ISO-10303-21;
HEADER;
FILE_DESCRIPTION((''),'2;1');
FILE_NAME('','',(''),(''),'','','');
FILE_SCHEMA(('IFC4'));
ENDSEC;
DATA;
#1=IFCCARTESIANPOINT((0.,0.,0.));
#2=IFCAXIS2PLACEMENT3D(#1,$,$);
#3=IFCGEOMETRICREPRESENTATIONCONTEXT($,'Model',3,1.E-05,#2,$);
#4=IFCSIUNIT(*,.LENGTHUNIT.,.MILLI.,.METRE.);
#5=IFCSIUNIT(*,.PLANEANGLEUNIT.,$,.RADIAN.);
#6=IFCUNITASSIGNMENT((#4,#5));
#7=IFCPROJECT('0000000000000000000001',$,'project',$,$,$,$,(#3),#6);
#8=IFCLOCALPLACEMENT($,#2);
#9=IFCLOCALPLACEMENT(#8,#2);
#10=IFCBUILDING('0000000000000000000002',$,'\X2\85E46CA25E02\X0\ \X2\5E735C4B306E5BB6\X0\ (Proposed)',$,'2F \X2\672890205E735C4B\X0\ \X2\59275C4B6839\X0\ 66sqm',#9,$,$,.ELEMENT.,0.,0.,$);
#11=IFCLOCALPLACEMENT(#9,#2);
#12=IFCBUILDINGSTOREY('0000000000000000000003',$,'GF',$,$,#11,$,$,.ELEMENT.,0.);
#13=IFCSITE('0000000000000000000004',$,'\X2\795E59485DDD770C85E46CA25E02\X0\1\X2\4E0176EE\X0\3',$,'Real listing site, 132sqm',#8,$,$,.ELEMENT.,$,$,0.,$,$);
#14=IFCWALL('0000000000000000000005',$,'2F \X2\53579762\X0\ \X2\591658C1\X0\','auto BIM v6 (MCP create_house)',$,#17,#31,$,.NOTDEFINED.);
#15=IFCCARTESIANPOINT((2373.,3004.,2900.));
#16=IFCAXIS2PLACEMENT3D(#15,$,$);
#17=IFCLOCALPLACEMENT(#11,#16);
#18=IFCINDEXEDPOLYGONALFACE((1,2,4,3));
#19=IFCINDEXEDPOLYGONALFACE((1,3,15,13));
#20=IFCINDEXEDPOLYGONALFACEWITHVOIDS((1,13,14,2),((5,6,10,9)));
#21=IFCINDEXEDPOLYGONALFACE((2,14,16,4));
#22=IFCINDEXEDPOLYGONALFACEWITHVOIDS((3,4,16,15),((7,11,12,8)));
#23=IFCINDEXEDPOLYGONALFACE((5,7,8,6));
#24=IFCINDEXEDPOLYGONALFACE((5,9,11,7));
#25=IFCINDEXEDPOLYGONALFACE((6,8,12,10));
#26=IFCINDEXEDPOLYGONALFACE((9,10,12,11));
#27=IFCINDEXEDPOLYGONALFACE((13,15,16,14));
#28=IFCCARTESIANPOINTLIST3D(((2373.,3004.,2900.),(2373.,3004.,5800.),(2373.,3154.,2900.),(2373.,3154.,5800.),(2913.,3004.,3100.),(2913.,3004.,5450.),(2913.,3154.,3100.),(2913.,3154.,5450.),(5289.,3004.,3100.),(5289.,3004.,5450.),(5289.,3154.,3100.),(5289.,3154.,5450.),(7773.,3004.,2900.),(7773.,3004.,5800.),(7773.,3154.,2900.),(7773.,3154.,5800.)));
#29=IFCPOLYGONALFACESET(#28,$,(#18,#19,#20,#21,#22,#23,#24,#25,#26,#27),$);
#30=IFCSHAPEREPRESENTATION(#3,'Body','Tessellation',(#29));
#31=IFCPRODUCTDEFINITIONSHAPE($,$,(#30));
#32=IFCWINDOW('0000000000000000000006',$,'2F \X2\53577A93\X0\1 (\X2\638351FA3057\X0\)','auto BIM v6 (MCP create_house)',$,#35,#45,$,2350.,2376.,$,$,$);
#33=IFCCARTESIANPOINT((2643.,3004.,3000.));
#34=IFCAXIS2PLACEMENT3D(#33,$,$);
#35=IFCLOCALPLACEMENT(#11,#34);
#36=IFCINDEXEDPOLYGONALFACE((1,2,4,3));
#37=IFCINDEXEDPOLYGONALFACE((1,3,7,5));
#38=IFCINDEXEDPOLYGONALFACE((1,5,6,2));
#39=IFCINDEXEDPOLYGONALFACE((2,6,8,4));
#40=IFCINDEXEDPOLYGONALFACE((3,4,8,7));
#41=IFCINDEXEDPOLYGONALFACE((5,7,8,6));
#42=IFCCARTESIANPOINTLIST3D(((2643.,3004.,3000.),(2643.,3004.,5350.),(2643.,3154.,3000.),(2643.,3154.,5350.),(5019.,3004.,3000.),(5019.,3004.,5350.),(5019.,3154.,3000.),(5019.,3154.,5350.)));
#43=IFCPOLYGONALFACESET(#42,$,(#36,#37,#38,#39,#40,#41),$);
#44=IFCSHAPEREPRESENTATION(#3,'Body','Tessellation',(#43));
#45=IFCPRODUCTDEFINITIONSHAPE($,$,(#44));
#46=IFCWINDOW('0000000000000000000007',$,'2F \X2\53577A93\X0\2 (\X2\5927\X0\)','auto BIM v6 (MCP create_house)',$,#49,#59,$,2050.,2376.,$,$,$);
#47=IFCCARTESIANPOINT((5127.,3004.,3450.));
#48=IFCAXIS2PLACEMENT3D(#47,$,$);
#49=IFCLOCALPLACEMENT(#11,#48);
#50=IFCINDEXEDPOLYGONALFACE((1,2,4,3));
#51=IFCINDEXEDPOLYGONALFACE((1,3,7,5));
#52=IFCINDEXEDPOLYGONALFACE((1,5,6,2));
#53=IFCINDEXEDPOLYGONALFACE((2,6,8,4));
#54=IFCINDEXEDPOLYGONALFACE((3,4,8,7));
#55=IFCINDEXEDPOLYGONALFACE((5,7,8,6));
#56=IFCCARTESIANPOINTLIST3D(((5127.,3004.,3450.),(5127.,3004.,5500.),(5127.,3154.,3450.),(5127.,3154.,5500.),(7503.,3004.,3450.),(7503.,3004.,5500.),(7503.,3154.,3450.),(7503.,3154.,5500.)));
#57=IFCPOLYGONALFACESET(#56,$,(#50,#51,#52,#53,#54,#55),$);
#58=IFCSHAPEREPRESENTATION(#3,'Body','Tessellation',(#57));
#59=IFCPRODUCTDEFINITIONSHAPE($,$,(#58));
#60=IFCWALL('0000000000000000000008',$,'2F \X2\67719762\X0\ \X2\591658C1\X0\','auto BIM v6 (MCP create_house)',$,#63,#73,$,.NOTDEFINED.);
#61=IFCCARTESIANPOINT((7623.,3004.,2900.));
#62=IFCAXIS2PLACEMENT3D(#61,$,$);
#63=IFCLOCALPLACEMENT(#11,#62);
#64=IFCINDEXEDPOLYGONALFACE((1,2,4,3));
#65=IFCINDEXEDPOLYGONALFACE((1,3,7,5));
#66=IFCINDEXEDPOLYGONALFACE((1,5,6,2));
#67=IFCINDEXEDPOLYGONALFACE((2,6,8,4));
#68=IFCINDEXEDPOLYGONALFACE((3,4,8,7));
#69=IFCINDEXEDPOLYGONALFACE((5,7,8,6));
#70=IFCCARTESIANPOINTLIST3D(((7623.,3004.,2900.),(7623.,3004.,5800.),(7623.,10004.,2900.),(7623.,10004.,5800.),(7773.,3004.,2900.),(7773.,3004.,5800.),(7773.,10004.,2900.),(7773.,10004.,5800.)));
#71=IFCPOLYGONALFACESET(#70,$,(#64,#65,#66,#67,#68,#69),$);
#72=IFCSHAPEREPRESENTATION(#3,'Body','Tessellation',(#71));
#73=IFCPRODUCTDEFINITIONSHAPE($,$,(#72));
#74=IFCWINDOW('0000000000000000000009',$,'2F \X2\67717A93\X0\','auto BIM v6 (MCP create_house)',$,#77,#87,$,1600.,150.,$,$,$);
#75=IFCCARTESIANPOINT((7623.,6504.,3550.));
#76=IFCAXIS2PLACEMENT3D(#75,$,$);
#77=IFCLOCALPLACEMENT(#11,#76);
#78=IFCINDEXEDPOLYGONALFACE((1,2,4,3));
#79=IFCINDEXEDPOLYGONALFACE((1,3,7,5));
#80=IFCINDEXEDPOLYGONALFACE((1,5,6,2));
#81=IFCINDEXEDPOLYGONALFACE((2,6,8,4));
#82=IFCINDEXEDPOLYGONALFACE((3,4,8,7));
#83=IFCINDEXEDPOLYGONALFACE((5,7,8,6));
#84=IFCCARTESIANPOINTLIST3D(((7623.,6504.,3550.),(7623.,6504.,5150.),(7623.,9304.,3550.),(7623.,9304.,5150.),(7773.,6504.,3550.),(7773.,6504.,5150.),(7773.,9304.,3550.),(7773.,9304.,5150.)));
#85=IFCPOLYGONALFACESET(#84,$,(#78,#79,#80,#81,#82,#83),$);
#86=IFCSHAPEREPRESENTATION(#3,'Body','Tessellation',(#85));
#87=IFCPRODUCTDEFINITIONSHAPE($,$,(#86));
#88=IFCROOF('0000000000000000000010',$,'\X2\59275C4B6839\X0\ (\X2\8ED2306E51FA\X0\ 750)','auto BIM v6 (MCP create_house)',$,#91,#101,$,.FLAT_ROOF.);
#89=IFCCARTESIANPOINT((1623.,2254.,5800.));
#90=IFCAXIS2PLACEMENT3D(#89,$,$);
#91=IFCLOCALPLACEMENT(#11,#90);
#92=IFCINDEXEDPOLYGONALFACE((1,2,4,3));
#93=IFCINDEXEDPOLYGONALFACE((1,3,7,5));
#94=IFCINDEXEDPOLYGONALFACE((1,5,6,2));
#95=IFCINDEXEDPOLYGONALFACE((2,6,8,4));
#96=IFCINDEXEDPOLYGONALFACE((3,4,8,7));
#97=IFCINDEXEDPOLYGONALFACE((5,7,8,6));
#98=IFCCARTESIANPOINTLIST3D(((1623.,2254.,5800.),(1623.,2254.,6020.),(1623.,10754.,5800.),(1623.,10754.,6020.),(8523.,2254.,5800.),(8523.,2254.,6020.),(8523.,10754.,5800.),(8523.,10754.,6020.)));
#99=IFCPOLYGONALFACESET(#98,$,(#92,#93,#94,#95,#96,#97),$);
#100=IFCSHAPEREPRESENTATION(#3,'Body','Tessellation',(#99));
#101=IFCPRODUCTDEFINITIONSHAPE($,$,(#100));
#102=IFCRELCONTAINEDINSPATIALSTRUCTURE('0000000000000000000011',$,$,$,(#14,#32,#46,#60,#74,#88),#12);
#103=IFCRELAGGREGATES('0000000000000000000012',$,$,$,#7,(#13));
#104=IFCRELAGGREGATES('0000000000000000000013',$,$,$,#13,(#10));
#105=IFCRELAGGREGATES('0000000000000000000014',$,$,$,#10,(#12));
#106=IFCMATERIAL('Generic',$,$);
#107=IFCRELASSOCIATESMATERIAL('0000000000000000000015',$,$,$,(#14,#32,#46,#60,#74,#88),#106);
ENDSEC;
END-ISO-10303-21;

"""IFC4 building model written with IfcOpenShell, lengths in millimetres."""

from ifc_helpers import new_model, si_unit, frame, frame_2d, origin, place, context, project, spatial, rectangle, extrude, material, element, fill, save


model = new_model("IFC4")

# Units and contexts
model_context = context("Model", 3, precision=1e-05, world=origin())
ifc_project = project(units=[si_unit("LENGTHUNIT", "METRE", prefix="MILLI"), si_unit("PLANEANGLEUNIT", "RADIAN")], contexts=[model_context])

# Site, building, storey
site_placement = place(None, origin())
site = spatial("IfcSite", under=ifc_project, at=site_placement, Name="神奈川県藤沢市1丁目3", ObjectType="Real listing site, 132sqm", CompositionType="ELEMENT", RefElevation=0.0)
building_placement = place(site_placement, origin())
building = spatial("IfcBuilding", under=site, at=building_placement, Name="藤沢市 平屋の家 (Proposed)", ObjectType="2F 木造平屋 大屋根 66sqm", CompositionType="ELEMENT", ElevationOfRefHeight=0.0, ElevationOfTerrain=0.0)
storey_placement = place(building_placement, origin())
storey = spatial("IfcBuildingStorey", under=building, at=storey_placement, Name="GF", CompositionType="ELEMENT", Elevation=0.0)

# Shared definitions
ifc_material = material(Name="Generic")

# Wall, openings, windows
wall_1_placement = place(storey_placement, frame((2373.0, 3004.0, 2900.0)))
wall_1 = element("IfcWall", 1, at=wall_1_placement, inside=storey, material=ifc_material, Name="2F 南面 外壁", Description="auto BIM v6 (MCP create_house)", PredefinedType="NOTDEFINED", context=model_context, shape_type="SweptSolid", body=[
    extrude(rectangle(XDim=5400.0, YDim=150.0, at=frame_2d((2700.0, 75.0))), frame((2373.0, 3004.0, 2900.0)), (0.0, 0.0, 1.0), 2900.0),
])
opening_1_placement = place(storey_placement, frame((2643.0, 3004.0, 3000.0)))
opening_1 = element("IfcOpeningElement", 2, at=opening_1_placement, cuts=wall_1, PredefinedType="NOTDEFINED", context=model_context, shape_type="SweptSolid", body=[
    extrude(rectangle(XDim=2376.0, YDim=150.0, at=frame_2d((1188.0, 75.0))), frame((2643.0, 3004.0, 3000.0)), (0.0, 0.0, 1.0), 2350.0),
])
opening_2_placement = place(storey_placement, frame((5127.0, 3004.0, 3450.0)))
opening_2 = element("IfcOpeningElement", 3, at=opening_2_placement, cuts=wall_1, PredefinedType="NOTDEFINED", context=model_context, shape_type="SweptSolid", body=[
    extrude(rectangle(XDim=2376.0, YDim=150.0, at=frame_2d((1188.0, 75.0))), frame((5127.0, 3004.0, 3450.0)), (0.0, 0.0, 1.0), 2050.0),
])
window_1_placement = place(storey_placement, frame((2643.0, 3004.0, 3000.0)))
window_1 = element("IfcWindow", 4, at=window_1_placement, inside=storey, material=ifc_material, Name="2F 南窓1 (掃出し)", Description="auto BIM v6 (MCP create_house)", OverallHeight=2350.0, OverallWidth=2376.0, context=model_context, shape_type="SweptSolid", body=[
    extrude(rectangle(XDim=2376.0, YDim=150.0, at=frame_2d((1188.0, 75.0))), frame((2643.0, 3004.0, 3000.0)), (0.0, 0.0, 1.0), 2350.0),
])
fill(opening_1, window_1)
window_2_placement = place(storey_placement, frame((5127.0, 3004.0, 3450.0)))
window_2 = element("IfcWindow", 5, at=window_2_placement, inside=storey, material=ifc_material, Name="2F 南窓2 (大)", Description="auto BIM v6 (MCP create_house)", OverallHeight=2050.0, OverallWidth=2376.0, context=model_context, shape_type="SweptSolid", body=[
    extrude(rectangle(XDim=2376.0, YDim=150.0, at=frame_2d((1188.0, 75.0))), frame((5127.0, 3004.0, 3450.0)), (0.0, 0.0, 1.0), 2050.0),
])
fill(opening_2, window_2)

# Wall, opening, window
wall_2_placement = place(storey_placement, frame((7623.0, 3004.0, 2900.0)))
wall_2 = element("IfcWall", 6, at=wall_2_placement, inside=storey, material=ifc_material, Name="2F 東面 外壁", Description="auto BIM v6 (MCP create_house)", PredefinedType="NOTDEFINED", context=model_context, shape_type="SweptSolid", body=[
    extrude(rectangle(XDim=150.0, YDim=7000.0, at=frame_2d((75.0, 3500.0))), frame((7623.0, 3004.0, 2900.0)), (0.0, 0.0, 1.0), 2900.0),
])
opening_3_placement = place(storey_placement, frame((7623.0, 6504.0, 3550.0)))
opening_3 = element("IfcOpeningElement", 7, at=opening_3_placement, cuts=wall_2, PredefinedType="NOTDEFINED", context=model_context, shape_type="SweptSolid", body=[
    extrude(rectangle(XDim=150.0, YDim=2800.0, at=frame_2d((75.0, 1400.0))), frame((7623.0, 6504.0, 3550.0)), (0.0, 0.0, 1.0), 1600.0),
])
window_3_placement = place(storey_placement, frame((7623.0, 6504.0, 3550.0)))
window_3 = element("IfcWindow", 8, at=window_3_placement, inside=storey, material=ifc_material, Name="2F 東窓", Description="auto BIM v6 (MCP create_house)", OverallHeight=1600.0, OverallWidth=150.0, context=model_context, shape_type="SweptSolid", body=[
    extrude(rectangle(XDim=150.0, YDim=2800.0, at=frame_2d((75.0, 1400.0))), frame((7623.0, 6504.0, 3550.0)), (0.0, 0.0, 1.0), 1600.0),
])
fill(opening_3, window_3)

# Roof
roof_placement = place(storey_placement, frame((1623.0, 2254.0, 5800.0)))
element("IfcRoof", 9, at=roof_placement, inside=storey, material=ifc_material, Name="大屋根 (軒の出 750)", Description="auto BIM v6 (MCP create_house)", PredefinedType="FLAT_ROOF", context=model_context, shape_type="SweptSolid", body=[
    extrude(rectangle(XDim=6900.0, YDim=8500.0, at=frame_2d((3450.0, 4250.0))), frame((1623.0, 2254.0, 5800.0)), (0.0, 0.0, 1.0), 220.0),
])

save(model, "model.ifc")
